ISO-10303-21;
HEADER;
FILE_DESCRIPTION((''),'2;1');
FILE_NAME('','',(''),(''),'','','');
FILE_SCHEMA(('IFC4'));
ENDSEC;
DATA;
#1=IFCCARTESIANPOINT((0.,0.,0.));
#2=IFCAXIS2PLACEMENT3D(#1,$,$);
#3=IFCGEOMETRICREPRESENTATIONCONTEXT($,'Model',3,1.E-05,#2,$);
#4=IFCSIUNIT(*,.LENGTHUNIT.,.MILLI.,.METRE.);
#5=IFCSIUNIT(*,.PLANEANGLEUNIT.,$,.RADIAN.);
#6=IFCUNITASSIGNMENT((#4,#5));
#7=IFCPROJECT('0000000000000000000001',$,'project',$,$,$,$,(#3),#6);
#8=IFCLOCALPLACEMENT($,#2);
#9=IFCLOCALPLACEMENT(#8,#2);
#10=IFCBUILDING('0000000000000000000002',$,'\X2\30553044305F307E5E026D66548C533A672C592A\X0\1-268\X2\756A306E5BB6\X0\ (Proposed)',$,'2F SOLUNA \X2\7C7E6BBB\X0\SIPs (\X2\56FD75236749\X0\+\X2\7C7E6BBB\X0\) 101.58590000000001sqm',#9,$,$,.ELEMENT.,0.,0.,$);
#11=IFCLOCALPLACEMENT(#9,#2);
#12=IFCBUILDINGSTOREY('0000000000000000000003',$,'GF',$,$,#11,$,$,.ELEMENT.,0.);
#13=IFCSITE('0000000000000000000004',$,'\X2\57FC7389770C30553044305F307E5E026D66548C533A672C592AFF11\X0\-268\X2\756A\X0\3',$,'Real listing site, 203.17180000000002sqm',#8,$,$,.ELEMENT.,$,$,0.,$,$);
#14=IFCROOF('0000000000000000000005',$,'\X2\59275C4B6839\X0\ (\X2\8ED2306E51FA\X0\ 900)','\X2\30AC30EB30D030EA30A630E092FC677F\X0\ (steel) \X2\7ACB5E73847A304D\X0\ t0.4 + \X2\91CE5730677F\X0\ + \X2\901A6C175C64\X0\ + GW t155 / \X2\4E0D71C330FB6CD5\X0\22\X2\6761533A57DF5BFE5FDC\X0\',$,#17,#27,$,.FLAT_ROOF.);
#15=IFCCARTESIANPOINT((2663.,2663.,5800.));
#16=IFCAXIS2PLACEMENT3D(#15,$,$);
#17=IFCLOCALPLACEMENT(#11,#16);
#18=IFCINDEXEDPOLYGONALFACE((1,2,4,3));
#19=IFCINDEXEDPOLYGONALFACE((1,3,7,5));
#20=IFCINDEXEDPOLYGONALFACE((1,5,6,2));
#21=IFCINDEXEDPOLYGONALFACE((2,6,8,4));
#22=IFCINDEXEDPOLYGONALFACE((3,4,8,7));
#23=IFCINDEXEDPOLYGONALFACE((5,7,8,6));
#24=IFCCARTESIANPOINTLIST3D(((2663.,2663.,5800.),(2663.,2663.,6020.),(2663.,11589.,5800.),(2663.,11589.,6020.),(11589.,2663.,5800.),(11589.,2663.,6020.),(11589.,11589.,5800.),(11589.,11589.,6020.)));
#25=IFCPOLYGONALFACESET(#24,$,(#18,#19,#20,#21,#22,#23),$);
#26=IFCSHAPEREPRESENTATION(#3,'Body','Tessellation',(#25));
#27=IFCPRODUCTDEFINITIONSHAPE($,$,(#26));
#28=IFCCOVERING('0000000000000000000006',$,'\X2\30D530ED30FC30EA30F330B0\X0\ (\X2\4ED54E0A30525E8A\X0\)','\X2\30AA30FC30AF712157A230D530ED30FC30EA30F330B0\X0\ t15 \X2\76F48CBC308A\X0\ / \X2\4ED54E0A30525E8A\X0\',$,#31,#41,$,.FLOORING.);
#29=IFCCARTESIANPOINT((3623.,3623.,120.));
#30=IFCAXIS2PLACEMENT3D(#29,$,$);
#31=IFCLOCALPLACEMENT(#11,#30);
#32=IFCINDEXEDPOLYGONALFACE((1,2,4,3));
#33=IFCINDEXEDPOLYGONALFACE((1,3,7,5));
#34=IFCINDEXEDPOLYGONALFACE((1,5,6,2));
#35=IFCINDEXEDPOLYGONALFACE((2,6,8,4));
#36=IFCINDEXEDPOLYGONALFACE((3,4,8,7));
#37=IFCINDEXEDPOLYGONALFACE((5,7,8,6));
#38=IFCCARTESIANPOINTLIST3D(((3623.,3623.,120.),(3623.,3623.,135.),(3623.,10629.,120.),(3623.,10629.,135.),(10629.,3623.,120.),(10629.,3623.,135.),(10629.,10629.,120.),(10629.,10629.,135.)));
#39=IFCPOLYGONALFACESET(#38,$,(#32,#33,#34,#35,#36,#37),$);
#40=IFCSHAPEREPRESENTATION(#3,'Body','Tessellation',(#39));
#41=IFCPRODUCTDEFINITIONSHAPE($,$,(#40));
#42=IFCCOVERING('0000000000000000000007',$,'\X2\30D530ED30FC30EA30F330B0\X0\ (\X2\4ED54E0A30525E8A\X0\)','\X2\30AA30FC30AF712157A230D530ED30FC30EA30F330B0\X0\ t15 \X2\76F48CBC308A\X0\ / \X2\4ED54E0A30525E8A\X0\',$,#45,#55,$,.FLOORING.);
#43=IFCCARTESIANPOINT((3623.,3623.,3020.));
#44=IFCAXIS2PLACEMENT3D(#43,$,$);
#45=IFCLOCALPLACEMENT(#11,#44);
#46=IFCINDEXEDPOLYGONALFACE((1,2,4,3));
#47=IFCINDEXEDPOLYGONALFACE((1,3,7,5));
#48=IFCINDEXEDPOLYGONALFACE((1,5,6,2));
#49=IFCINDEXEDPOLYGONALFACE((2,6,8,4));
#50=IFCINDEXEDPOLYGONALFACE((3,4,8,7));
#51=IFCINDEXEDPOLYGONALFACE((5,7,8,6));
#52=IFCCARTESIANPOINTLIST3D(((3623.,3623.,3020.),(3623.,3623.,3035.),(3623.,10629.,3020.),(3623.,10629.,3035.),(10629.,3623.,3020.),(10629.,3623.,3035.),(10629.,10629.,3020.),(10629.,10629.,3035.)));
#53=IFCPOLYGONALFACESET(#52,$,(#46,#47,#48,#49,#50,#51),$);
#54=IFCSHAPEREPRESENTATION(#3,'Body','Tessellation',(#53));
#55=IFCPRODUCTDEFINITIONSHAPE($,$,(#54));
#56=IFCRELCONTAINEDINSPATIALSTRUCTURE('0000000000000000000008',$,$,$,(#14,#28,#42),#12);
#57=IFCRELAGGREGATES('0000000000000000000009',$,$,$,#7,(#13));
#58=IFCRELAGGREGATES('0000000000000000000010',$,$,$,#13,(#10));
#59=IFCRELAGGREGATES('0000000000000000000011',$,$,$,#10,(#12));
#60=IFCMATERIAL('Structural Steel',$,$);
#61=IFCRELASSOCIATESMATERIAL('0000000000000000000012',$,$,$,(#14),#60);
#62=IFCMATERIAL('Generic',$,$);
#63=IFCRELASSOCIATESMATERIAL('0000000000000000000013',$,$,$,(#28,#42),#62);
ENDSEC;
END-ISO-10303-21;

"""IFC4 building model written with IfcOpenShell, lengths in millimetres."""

from ifc_helpers import new_model, si_unit, frame, frame_2d, origin, place, context, project, spatial, rectangle, extrude, material, element, save


model = new_model("IFC4")

# Units and contexts
model_context = context("Model", 3, precision=1e-05, world=origin())
ifc_project = project(units=[si_unit("LENGTHUNIT", "METRE", prefix="MILLI"), si_unit("PLANEANGLEUNIT", "RADIAN")], contexts=[model_context])

# Site, building, storey
site_placement = place(None, origin())
site = spatial("IfcSite", under=ifc_project, at=site_placement, Name="埼玉県さいたま市浦和区本太１-268番3", ObjectType="Real listing site, 203.17180000000002sqm", CompositionType="ELEMENT", RefElevation=0.0)
building_placement = place(site_placement, origin())
building = spatial("IfcBuilding", under=site, at=building_placement, Name="さいたま市浦和区本太1-268番の家 (Proposed)", ObjectType="2F SOLUNA 籾殻SIPs (国産杉+籾殻) 101.58590000000001sqm", CompositionType="ELEMENT", ElevationOfRefHeight=0.0, ElevationOfTerrain=0.0)
storey_placement = place(building_placement, origin())
storey = spatial("IfcBuildingStorey", under=building, at=storey_placement, Name="GF", CompositionType="ELEMENT", Elevation=0.0)

# Roof
ifc_material_1 = material(Name="Structural Steel")
roof_placement = place(storey_placement, frame((2663.0, 2663.0, 5800.0)))
element("IfcRoof", 1, at=roof_placement, inside=storey, material=ifc_material_1, Name="大屋根 (軒の出 900)", Description="ガルバリウム鋼板 (steel) 立平葺き t0.4 + 野地板 + 通気層 + GW t155 / 不燃・法22条区域対応", PredefinedType="FLAT_ROOF", context=model_context, shape_type="SweptSolid", body=[
    extrude(rectangle(XDim=8926.0, YDim=8926.0, at=frame_2d((4463.0, 4463.0))), frame((2663.0, 2663.0, 5800.0)), (0.0, 0.0, 1.0), 220.0),
])

# Coverings
ifc_material_2 = material(Name="Generic")
covering_1_placement = place(storey_placement, frame((3623.0, 3623.0, 120.0)))
element("IfcCovering", 2, at=covering_1_placement, inside=storey, material=ifc_material_2, Name="フローリング (仕上げ床)", Description="オーク無垢フローリング t15 直貼り / 仕上げ床", PredefinedType="FLOORING", context=model_context, shape_type="SweptSolid", body=[
    extrude(rectangle(XDim=7006.0, YDim=7006.0, at=frame_2d((3503.0, 3503.0))), frame((3623.0, 3623.0, 120.0)), (0.0, 0.0, 1.0), 15.0),
])
covering_2_placement = place(storey_placement, frame((3623.0, 3623.0, 3020.0)))
element("IfcCovering", 3, at=covering_2_placement, inside=storey, material=ifc_material_2, Name="フローリング (仕上げ床)", Description="オーク無垢フローリング t15 直貼り / 仕上げ床", PredefinedType="FLOORING", context=model_context, shape_type="SweptSolid", body=[
    extrude(rectangle(XDim=7006.0, YDim=7006.0, at=frame_2d((3503.0, 3503.0))), frame((3623.0, 3623.0, 3020.0)), (0.0, 0.0, 1.0), 15.0),
])

save(model, "model.ifc")
